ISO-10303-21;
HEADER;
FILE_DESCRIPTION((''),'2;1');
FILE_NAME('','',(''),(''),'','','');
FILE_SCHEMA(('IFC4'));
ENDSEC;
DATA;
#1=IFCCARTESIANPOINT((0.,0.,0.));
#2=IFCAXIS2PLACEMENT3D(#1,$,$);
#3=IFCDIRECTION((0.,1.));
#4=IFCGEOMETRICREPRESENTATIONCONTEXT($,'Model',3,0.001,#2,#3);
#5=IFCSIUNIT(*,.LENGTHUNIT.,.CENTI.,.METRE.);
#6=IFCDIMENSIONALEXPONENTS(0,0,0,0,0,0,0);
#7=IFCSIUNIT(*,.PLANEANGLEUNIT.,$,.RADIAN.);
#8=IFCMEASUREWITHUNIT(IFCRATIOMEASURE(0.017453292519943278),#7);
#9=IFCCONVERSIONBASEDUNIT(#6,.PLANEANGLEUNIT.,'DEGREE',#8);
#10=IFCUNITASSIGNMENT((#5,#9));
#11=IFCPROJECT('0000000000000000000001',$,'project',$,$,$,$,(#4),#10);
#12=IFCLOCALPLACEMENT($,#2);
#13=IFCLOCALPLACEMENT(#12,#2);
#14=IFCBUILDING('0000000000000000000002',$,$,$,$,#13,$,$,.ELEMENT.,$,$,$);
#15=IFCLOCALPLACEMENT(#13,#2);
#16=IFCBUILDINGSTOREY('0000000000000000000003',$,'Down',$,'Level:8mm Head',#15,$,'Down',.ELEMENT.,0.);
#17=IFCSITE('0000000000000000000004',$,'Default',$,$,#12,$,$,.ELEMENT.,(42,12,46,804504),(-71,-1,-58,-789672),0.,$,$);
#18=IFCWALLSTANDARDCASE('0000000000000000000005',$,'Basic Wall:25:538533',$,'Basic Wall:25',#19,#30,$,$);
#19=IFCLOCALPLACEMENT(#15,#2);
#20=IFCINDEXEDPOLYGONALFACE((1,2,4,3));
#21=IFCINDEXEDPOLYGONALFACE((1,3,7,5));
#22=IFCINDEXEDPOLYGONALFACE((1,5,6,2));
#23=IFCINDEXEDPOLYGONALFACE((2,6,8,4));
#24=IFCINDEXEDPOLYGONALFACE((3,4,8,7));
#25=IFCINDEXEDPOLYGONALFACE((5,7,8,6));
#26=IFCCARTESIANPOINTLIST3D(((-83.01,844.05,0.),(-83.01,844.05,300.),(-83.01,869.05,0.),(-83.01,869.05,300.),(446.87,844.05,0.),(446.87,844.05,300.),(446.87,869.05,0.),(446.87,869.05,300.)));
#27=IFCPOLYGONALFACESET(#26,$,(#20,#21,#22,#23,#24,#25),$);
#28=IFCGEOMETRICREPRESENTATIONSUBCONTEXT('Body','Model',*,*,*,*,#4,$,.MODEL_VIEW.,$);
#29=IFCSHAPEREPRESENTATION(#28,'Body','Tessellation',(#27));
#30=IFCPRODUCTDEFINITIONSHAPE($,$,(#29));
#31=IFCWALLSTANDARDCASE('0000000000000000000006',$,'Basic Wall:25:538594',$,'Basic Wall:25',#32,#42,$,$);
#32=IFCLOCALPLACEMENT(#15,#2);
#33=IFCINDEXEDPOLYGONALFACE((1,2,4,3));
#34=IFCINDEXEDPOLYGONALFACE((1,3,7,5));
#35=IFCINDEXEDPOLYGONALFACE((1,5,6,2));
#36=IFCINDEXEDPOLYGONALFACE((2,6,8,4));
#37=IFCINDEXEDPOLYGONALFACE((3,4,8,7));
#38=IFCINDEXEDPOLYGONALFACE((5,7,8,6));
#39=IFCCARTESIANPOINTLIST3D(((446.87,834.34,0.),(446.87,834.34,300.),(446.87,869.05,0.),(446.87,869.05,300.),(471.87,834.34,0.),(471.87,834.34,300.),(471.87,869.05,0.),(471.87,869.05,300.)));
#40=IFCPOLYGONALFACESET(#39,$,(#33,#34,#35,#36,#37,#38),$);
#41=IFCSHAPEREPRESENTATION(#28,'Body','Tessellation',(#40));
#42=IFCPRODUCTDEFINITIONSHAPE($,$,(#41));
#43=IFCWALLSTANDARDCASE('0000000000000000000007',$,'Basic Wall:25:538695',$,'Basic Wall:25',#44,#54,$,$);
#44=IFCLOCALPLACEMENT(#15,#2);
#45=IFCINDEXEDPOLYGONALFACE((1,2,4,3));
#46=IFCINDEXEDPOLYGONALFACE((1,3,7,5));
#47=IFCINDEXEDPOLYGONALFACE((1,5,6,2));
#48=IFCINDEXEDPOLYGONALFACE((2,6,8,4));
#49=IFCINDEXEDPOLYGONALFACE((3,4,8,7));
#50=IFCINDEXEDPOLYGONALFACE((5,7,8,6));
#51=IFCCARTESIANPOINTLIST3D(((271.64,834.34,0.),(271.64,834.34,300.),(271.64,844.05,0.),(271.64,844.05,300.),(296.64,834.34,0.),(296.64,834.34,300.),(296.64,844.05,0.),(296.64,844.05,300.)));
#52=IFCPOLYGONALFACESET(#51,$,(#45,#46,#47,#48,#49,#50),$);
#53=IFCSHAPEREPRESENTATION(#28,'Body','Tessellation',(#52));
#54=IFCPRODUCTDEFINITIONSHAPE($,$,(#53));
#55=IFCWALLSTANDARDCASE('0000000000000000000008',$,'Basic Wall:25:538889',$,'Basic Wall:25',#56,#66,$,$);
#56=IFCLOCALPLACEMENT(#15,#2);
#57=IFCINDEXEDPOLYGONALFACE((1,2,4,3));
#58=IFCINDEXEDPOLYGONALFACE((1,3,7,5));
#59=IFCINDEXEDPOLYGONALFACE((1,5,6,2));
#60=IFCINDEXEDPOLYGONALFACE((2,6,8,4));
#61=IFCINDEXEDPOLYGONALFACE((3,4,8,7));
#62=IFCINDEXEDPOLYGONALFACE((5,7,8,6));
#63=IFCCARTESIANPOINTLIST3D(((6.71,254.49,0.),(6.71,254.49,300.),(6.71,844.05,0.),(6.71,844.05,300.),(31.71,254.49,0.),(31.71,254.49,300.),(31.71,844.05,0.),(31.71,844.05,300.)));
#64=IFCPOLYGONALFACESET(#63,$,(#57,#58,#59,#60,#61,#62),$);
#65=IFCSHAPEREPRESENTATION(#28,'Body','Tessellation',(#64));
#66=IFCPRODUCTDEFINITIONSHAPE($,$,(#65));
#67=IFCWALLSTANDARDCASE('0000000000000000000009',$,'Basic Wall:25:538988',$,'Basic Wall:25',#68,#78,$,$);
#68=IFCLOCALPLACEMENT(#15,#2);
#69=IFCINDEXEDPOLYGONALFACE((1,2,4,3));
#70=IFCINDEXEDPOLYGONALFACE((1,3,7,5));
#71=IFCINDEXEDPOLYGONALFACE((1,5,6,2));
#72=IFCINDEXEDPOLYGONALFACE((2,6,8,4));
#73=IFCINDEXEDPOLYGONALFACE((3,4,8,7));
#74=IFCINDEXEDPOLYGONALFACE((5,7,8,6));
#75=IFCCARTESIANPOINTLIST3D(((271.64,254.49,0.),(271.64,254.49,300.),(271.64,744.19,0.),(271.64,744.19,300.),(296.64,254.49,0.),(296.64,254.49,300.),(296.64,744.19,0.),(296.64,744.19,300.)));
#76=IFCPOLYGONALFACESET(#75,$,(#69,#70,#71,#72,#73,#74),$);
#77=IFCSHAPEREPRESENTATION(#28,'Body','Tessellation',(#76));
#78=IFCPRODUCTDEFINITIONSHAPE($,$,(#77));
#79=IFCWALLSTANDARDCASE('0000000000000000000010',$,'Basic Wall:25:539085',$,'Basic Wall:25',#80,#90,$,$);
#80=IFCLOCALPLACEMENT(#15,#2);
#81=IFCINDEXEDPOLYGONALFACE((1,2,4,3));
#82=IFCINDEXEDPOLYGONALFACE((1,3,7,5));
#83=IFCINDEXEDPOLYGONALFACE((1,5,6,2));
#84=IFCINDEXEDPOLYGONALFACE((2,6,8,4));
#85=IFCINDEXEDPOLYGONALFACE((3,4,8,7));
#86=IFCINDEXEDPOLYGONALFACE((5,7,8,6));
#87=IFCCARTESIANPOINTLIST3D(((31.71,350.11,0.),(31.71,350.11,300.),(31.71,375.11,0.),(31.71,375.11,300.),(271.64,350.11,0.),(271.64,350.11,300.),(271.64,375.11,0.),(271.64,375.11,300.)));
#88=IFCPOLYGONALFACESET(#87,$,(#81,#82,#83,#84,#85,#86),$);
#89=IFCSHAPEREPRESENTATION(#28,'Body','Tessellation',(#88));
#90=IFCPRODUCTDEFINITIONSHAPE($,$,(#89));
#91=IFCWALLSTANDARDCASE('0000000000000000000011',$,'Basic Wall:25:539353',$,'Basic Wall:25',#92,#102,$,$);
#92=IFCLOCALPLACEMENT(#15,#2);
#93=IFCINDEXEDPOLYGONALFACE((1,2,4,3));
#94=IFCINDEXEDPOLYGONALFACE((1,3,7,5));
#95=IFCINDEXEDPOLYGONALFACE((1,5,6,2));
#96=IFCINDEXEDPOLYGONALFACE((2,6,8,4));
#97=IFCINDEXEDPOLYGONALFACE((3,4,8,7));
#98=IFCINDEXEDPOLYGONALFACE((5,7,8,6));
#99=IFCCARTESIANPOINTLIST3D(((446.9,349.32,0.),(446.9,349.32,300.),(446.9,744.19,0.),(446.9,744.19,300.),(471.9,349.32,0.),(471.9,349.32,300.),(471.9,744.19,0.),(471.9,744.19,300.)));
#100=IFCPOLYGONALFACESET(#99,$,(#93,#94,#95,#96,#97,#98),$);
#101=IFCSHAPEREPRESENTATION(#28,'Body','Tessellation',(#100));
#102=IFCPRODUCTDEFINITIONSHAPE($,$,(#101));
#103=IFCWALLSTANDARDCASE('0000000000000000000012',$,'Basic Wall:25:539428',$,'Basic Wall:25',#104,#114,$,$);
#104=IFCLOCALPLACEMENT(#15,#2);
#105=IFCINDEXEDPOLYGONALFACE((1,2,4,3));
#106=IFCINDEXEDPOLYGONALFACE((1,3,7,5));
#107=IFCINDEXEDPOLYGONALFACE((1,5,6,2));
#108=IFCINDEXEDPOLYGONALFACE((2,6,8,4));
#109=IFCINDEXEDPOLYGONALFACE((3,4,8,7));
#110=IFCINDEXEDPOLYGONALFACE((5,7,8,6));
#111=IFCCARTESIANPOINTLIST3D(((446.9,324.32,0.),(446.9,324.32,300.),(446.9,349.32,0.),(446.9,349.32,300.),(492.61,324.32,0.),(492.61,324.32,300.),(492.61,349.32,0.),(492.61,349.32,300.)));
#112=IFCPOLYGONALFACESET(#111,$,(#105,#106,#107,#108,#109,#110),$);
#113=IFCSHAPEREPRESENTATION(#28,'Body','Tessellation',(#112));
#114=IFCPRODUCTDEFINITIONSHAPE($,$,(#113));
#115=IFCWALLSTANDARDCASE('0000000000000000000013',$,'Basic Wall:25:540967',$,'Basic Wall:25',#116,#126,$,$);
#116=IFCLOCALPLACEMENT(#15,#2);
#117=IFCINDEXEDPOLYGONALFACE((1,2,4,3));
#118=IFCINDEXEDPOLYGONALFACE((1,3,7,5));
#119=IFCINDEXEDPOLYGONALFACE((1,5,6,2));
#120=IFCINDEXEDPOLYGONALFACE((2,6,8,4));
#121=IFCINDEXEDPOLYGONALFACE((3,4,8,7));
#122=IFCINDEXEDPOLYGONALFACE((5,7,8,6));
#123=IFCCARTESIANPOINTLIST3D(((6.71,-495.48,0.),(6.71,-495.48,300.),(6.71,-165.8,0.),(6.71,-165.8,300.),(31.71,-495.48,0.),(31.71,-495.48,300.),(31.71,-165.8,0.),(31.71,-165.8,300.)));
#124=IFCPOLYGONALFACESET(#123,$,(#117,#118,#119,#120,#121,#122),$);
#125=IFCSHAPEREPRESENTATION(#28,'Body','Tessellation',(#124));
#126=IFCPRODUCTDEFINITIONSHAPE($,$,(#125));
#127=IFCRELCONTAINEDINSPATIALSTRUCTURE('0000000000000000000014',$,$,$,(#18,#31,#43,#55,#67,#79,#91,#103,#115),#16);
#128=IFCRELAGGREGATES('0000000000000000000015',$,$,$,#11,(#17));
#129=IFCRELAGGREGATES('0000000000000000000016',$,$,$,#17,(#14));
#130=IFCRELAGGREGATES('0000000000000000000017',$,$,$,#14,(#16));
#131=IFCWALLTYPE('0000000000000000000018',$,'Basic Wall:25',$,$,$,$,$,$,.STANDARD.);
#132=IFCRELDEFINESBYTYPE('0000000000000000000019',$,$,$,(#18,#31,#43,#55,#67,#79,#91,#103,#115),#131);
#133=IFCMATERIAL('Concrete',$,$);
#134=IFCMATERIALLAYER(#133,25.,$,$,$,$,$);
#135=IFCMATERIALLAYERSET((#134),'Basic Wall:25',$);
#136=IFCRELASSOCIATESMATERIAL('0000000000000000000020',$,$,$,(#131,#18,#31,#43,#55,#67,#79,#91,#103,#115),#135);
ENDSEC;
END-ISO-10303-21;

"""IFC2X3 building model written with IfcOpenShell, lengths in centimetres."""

from ifc_helpers import new_model, entity, si_unit, converted_unit, direction, frame, frame_2d, origin, place, context, subcontext, project, spatial, rectangle, extrude, material, layer, layer_set, layer_usage, type_object, element, save


model = new_model("IFC2X3")

# Units and contexts
model_context = context("Model", 3, precision=0.001, world=origin(), true_north=direction((0.0, 1.0)))
body_context = subcontext(model_context, "Body", "Model", "MODEL_VIEW")
ifc_project = project(units=[si_unit("LENGTHUNIT", "METRE", prefix="CENTI"), converted_unit("PLANEANGLEUNIT", "DEGREE", entity("IfcRatioMeasure", 0.017453292519943278), si_unit("PLANEANGLEUNIT", "RADIAN"), dimensions=[0, 0, 0, 0, 0, 0, 0])], contexts=[model_context])

# Site, building, storey
site_placement = place(None, origin())
site = spatial("IfcSite", under=ifc_project, at=site_placement, Name="Default", CompositionType="ELEMENT", RefLatitude=(42, 12, 46, 804504), RefLongitude=(-71, -1, -58, -789672), RefElevation=0.0)
building_placement = place(site_placement, origin())
building = spatial("IfcBuilding", under=site, at=building_placement, CompositionType="ELEMENT")
storey_placement = place(building_placement, origin())
storey = spatial("IfcBuildingStorey", under=building, at=storey_placement, Name="Down", ObjectType="Level:8mm Head", LongName="Down", CompositionType="ELEMENT", Elevation=0.0)

# Shared definitions
ifc_material = material(Name="Concrete")

# Walls
ifc_layer = layer(ifc_material, 25.0)
ifc_layer_set = layer_set([ifc_layer], Name="Basic Wall:25")
wall_type = type_object("IfcWallType", Name="Basic Wall:25", PredefinedType="STANDARD", material=ifc_layer_set)
ifc_layer_usage_1 = layer_usage(ifc_layer_set, "AXIS2", "NEGATIVE", 12.5)
wall_1_placement = place(storey_placement, frame((-83.01, 856.55, 0.0)))
element("IfcWallStandardCase", 1, at=wall_1_placement, inside=storey, type_object=wall_type, material=ifc_layer_usage_1, Name="Basic Wall:25:538533", ObjectType="Basic Wall:25", context=body_context, shape_type="SweptSolid", body=[
    extrude(rectangle(XDim=529.88, YDim=25.0, at=frame_2d((264.94, 0.0), x_axis=(-1.0, 0.0))), origin(), (0.0, 0.0, 1.0), 300.0),
])
ifc_layer_usage_2 = layer_usage(ifc_layer_set, "AXIS2", "NEGATIVE", 12.5)
wall_2_placement = place(storey_placement, frame((459.37, 869.05, 0.0), z_axis=(0.0, 0.0, 1.0), x_axis=(0.0, -1.0, 0.0)))
element("IfcWallStandardCase", 2, at=wall_2_placement, inside=storey, type_object=wall_type, material=ifc_layer_usage_2, Name="Basic Wall:25:538594", ObjectType="Basic Wall:25", context=body_context, shape_type="SweptSolid", body=[
    extrude(rectangle(XDim=34.71, YDim=25.0, at=frame_2d((17.35, 0.0), x_axis=(-1.0, 0.0))), origin(), (0.0, 0.0, 1.0), 300.0),
])
ifc_layer_usage_3 = layer_usage(ifc_layer_set, "AXIS2", "POSITIVE", -12.5)
wall_3_placement = place(storey_placement, frame((284.14, 834.34, 0.0), z_axis=(0.0, 0.0, 1.0), x_axis=(0.0, 1.0, 0.0)))
element("IfcWallStandardCase", 3, at=wall_3_placement, inside=storey, type_object=wall_type, material=ifc_layer_usage_3, Name="Basic Wall:25:538695", ObjectType="Basic Wall:25", context=body_context, shape_type="SweptSolid", body=[
    extrude(rectangle(XDim=9.71, YDim=25.0, at=frame_2d((4.85, 0.0), x_axis=(-1.0, 0.0))), origin(), (0.0, 0.0, 1.0), 300.0),
])
ifc_layer_usage_4 = layer_usage(ifc_layer_set, "AXIS2", "POSITIVE", -12.5)
wall_4_placement = place(storey_placement, frame((19.21, 844.05, 0.0), z_axis=(0.0, 0.0, 1.0), x_axis=(0.0, -1.0, 0.0)))
element("IfcWallStandardCase", 4, at=wall_4_placement, inside=storey, type_object=wall_type, material=ifc_layer_usage_4, Name="Basic Wall:25:538889", ObjectType="Basic Wall:25", context=body_context, shape_type="SweptSolid", body=[
    extrude(rectangle(XDim=589.56, YDim=25.0, at=frame_2d((294.78, 0.0), x_axis=(-1.0, 0.0))), origin(), (0.0, 0.0, 1.0), 300.0),
])
ifc_layer_usage_5 = layer_usage(ifc_layer_set, "AXIS2", "POSITIVE", -12.5)
wall_5_placement = place(storey_placement, frame((284.14, 254.49, 0.0), z_axis=(0.0, 0.0, 1.0), x_axis=(0.0, 1.0, 0.0)))
element("IfcWallStandardCase", 5, at=wall_5_placement, inside=storey, type_object=wall_type, material=ifc_layer_usage_5, Name="Basic Wall:25:538988", ObjectType="Basic Wall:25", context=body_context, shape_type="SweptSolid", body=[
    extrude(rectangle(XDim=489.7, YDim=25.0, at=frame_2d((244.85, 0.0), x_axis=(-1.0, 0.0))), origin(), (0.0, 0.0, 1.0), 300.0),
])
ifc_layer_usage_6 = layer_usage(ifc_layer_set, "AXIS2", "NEGATIVE", 12.5)
wall_6_placement = place(storey_placement, frame((31.71, 362.61, 0.0)))
element("IfcWallStandardCase", 6, at=wall_6_placement, inside=storey, type_object=wall_type, material=ifc_layer_usage_6, Name="Basic Wall:25:539085", ObjectType="Basic Wall:25", context=body_context, shape_type="SweptSolid", body=[
    extrude(rectangle(XDim=239.93, YDim=25.0, at=frame_2d((119.96, 0.0), x_axis=(-1.0, 0.0))), origin(), (0.0, 0.0, 1.0), 300.0),
])
ifc_layer_usage_7 = layer_usage(ifc_layer_set, "AXIS2", "NEGATIVE", 12.5)
wall_7_placement = place(storey_placement, frame((459.4, 349.32, 0.0), z_axis=(0.0, 0.0, 1.0), x_axis=(0.0, 1.0, 0.0)))
element("IfcWallStandardCase", 7, at=wall_7_placement, inside=storey, type_object=wall_type, material=ifc_layer_usage_7, Name="Basic Wall:25:539353", ObjectType="Basic Wall:25", context=body_context, shape_type="SweptSolid", body=[
    extrude(rectangle(XDim=394.86, YDim=25.0, at=frame_2d((197.43, 0.0), x_axis=(-1.0, 0.0))), origin(), (0.0, 0.0, 1.0), 300.0),
])
ifc_layer_usage_8 = layer_usage(ifc_layer_set, "AXIS2", "POSITIVE", -12.5)
wall_8_placement = place(storey_placement, frame((446.9, 336.82, 0.0)))
element("IfcWallStandardCase", 8, at=wall_8_placement, inside=storey, type_object=wall_type, material=ifc_layer_usage_8, Name="Basic Wall:25:539428", ObjectType="Basic Wall:25", context=body_context, shape_type="SweptSolid", body=[
    extrude(rectangle(XDim=45.71, YDim=25.0, at=frame_2d((22.86, 0.0), x_axis=(-1.0, 0.0))), origin(), (0.0, 0.0, 1.0), 300.0),
])
ifc_layer_usage_9 = layer_usage(ifc_layer_set, "AXIS2", "POSITIVE", -12.5)
wall_9_placement = place(storey_placement, frame((19.21, -495.48, 0.0), z_axis=(0.0, 0.0, 1.0), x_axis=(0.0, 1.0, 0.0)))
element("IfcWallStandardCase", 9, at=wall_9_placement, inside=storey, type_object=wall_type, material=ifc_layer_usage_9, Name="Basic Wall:25:540967", ObjectType="Basic Wall:25", context=body_context, shape_type="SweptSolid", body=[
    extrude(rectangle(XDim=329.68, YDim=25.0, at=frame_2d((164.84, 0.0), x_axis=(-1.0, 0.0))), origin(), (0.0, 0.0, 1.0), 300.0),
])

save(model, "model.ifc")
